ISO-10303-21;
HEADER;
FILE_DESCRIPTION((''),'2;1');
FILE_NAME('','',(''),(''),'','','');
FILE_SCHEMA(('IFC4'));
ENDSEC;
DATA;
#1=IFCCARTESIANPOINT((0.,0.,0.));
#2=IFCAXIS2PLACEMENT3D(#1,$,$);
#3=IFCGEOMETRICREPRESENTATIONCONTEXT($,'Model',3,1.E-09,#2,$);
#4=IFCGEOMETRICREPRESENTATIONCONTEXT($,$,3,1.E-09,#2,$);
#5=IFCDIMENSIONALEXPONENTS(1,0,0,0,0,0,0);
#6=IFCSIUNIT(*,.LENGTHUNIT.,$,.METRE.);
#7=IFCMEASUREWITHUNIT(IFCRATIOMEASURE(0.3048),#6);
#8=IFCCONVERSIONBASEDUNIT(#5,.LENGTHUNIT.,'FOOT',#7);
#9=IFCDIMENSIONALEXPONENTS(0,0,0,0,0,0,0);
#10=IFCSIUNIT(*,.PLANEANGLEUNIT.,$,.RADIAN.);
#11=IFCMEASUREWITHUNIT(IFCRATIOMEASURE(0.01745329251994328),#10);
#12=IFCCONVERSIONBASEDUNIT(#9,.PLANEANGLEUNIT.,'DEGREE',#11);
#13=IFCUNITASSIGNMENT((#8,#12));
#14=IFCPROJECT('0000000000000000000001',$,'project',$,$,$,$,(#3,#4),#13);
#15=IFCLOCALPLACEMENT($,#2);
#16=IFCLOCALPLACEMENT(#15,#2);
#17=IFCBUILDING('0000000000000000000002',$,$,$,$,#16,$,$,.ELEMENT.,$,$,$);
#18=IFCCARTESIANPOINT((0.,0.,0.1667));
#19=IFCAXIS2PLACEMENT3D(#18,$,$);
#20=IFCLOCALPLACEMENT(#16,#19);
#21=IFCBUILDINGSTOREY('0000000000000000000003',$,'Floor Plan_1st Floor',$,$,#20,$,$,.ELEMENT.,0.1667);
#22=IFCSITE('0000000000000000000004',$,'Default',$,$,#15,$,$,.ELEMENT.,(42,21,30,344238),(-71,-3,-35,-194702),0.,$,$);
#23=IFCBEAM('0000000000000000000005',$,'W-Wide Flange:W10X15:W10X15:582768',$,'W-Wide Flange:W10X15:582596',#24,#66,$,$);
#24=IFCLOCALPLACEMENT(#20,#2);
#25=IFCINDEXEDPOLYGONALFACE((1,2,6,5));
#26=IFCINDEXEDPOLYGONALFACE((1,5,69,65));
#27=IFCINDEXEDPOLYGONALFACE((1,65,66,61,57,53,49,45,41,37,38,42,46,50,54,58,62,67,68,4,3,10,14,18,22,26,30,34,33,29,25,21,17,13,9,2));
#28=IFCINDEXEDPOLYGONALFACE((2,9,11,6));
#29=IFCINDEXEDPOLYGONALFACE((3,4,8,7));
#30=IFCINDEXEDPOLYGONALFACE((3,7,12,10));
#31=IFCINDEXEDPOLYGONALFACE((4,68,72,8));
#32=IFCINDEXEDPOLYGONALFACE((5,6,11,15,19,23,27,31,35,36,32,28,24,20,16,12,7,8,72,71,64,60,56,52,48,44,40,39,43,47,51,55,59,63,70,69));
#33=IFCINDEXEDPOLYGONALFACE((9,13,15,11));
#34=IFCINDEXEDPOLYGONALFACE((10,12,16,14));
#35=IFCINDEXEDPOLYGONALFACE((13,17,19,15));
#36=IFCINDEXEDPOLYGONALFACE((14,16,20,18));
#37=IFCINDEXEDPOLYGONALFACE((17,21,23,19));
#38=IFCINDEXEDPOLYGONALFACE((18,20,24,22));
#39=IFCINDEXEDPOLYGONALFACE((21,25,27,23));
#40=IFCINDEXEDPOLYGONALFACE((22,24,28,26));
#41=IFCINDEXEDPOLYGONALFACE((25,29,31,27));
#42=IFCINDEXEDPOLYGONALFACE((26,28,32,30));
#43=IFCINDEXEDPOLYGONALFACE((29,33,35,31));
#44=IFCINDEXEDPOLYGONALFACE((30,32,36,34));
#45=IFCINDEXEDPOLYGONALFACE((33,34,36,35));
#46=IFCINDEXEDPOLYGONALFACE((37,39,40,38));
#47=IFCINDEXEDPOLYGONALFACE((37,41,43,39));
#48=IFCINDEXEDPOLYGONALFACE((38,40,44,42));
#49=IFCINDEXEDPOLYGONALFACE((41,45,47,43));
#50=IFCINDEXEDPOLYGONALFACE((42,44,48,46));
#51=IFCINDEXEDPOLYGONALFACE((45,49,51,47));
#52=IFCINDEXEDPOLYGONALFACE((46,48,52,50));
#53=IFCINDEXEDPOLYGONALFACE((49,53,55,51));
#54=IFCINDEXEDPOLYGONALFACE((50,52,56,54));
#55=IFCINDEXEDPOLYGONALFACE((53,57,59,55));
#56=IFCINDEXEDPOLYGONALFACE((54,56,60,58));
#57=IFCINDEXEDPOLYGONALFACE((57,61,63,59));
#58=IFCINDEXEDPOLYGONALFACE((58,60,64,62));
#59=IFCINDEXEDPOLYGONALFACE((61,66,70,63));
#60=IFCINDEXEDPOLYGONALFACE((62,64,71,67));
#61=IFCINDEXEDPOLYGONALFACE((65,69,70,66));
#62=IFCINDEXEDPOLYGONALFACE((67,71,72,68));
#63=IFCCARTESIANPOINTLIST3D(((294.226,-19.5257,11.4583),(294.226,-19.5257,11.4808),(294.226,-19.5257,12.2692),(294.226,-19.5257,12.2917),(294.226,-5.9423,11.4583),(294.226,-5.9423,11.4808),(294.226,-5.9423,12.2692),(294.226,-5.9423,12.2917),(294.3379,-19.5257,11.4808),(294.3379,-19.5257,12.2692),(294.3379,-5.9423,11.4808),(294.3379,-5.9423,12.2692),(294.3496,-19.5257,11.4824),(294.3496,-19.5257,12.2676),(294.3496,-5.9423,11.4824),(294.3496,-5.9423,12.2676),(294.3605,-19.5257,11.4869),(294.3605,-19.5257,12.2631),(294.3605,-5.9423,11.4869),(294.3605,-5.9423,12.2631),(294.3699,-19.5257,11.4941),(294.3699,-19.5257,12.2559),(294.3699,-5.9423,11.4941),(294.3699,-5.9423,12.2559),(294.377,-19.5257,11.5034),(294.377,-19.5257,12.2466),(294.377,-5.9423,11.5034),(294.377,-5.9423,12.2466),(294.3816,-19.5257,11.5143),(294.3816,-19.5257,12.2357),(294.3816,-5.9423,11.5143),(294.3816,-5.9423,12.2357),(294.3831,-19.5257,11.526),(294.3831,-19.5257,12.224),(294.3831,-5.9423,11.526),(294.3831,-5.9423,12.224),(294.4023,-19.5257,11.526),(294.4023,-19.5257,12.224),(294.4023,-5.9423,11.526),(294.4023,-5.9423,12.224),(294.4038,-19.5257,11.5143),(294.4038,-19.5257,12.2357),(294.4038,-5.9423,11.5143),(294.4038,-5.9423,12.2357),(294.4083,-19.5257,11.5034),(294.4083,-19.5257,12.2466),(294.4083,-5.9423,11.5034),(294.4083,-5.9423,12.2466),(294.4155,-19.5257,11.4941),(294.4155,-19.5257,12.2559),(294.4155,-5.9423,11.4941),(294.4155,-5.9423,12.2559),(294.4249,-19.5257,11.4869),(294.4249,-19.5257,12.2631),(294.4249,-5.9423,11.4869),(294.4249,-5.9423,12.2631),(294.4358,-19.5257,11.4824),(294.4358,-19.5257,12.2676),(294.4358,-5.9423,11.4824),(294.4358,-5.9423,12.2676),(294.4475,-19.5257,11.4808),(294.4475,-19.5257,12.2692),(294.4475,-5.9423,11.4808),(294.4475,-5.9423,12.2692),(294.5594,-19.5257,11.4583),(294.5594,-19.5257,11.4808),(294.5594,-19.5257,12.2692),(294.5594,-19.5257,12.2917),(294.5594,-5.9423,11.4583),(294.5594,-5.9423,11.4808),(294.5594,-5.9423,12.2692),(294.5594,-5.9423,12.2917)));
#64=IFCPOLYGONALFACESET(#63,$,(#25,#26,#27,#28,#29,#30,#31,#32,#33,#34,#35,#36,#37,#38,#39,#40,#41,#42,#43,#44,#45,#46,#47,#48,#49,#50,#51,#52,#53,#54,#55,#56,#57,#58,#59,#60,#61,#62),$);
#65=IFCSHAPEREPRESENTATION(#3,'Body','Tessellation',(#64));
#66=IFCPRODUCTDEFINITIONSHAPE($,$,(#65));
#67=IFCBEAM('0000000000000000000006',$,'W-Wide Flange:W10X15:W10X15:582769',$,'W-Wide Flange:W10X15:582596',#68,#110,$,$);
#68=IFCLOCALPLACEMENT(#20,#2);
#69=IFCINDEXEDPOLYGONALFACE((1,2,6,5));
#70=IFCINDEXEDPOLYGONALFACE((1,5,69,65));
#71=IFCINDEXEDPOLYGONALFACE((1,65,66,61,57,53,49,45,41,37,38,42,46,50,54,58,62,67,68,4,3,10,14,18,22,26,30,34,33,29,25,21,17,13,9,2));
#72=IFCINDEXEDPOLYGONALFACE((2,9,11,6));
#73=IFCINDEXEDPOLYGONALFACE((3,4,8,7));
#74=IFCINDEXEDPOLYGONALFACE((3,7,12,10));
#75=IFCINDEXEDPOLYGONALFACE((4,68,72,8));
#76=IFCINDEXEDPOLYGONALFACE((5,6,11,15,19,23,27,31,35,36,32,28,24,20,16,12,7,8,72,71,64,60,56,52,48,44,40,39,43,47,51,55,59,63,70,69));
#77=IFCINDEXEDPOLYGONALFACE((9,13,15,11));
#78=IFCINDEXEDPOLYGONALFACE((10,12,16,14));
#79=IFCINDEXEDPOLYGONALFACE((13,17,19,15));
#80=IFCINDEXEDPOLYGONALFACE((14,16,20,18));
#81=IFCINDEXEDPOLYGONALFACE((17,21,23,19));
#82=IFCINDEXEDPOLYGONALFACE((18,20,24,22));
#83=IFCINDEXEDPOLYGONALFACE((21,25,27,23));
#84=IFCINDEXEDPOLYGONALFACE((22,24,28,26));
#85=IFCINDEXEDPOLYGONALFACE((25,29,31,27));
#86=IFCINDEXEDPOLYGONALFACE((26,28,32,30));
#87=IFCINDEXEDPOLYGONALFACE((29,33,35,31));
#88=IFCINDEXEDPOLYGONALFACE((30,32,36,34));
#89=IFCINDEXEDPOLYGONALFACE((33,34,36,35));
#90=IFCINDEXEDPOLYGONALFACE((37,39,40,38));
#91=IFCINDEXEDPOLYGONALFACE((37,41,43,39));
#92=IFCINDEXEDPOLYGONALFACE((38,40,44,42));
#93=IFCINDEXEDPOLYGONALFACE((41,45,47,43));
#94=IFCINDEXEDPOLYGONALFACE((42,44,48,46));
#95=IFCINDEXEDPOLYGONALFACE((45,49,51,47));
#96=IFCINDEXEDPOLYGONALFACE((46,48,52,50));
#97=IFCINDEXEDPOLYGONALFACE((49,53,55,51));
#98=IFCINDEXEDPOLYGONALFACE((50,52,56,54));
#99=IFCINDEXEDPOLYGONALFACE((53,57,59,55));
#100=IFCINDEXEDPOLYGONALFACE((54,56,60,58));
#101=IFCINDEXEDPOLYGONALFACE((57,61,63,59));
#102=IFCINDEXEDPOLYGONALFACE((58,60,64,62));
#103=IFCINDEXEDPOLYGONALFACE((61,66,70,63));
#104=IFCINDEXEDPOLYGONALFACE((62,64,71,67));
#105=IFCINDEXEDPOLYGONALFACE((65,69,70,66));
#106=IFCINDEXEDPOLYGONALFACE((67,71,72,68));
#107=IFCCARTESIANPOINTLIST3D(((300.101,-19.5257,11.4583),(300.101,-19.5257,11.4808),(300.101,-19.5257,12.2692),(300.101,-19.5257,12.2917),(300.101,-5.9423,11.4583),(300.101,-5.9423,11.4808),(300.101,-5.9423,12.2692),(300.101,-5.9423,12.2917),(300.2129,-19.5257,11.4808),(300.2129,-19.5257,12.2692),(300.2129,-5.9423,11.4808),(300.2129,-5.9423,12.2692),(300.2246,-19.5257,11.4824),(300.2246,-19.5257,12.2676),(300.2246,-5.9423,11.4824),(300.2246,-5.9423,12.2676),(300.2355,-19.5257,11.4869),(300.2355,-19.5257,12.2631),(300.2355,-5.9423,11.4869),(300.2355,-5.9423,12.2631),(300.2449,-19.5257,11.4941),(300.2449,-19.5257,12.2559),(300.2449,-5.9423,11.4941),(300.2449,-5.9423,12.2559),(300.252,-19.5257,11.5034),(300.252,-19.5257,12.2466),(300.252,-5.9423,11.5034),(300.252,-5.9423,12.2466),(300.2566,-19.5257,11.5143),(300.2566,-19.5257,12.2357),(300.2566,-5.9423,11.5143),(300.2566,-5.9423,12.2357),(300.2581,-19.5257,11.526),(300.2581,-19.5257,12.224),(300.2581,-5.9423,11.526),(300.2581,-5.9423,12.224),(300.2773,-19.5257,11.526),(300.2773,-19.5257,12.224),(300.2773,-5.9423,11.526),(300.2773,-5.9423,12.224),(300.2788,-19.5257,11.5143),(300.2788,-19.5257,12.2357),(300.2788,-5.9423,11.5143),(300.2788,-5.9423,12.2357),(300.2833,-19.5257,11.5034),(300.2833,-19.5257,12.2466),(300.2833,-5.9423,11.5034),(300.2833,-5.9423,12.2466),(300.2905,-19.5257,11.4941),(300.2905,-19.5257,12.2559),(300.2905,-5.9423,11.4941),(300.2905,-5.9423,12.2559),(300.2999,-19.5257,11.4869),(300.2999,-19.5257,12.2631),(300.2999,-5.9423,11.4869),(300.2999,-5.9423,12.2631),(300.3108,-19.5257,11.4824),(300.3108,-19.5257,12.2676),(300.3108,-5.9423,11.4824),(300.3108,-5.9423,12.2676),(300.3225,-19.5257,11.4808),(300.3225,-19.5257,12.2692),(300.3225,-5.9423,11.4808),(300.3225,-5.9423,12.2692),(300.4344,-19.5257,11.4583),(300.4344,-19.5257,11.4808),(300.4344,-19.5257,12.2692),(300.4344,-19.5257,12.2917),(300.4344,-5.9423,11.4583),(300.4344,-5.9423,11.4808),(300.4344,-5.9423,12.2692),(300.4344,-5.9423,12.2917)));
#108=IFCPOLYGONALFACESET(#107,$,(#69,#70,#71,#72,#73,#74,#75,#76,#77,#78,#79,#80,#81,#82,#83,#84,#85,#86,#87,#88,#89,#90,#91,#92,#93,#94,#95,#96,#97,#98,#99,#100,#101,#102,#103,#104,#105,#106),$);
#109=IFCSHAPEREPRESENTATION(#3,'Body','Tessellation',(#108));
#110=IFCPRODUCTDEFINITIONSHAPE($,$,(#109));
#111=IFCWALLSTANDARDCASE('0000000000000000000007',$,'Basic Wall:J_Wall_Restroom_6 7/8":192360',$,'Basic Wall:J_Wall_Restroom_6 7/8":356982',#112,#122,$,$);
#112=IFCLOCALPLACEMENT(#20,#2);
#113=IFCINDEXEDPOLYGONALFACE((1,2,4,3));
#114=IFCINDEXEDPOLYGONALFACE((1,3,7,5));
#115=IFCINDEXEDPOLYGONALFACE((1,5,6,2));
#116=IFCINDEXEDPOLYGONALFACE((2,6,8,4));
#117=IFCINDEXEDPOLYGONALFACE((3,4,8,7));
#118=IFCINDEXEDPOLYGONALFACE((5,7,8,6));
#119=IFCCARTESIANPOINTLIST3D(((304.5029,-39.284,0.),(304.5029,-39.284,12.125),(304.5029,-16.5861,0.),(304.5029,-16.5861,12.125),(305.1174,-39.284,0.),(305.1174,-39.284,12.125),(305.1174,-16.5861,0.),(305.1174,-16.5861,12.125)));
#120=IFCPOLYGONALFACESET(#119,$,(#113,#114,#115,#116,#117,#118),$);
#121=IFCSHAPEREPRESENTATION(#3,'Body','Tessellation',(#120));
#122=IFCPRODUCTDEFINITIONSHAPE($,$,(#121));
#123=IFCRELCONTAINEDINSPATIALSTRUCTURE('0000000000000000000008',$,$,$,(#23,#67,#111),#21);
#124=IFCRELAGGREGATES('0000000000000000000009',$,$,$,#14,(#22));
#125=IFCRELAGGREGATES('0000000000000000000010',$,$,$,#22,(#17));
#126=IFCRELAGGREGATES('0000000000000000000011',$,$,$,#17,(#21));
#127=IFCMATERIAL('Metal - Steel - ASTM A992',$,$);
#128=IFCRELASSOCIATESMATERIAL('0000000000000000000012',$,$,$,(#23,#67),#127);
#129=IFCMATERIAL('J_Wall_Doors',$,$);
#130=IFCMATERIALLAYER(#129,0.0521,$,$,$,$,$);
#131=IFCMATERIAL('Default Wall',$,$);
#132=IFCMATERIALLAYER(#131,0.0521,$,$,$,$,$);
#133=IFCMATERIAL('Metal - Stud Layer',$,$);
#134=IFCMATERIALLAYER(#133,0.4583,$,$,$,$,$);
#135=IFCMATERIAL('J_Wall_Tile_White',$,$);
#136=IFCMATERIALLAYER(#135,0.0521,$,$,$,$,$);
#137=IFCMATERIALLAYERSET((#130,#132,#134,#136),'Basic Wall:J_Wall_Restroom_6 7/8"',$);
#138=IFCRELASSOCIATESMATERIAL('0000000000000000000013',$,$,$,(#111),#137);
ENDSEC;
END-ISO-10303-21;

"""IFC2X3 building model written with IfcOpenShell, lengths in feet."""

from ifc_helpers import new_model, entity, si_unit, converted_unit, frame, frame_2d, origin, place, context, project, spatial, polyline, circle_curve, parameter, trimmed, segment, composite_curve, rectangle, outline, extrude, clip, halfspace, material, layer, layer_set, layer_usage, element, save


model = new_model("IFC2X3")

# Units and contexts
model_context = context("Model", 3, precision=1e-09, world=origin())
context_of_model = context(None, 3, precision=1e-09, world=origin())
ifc_project = project(units=[converted_unit("LENGTHUNIT", "FOOT", entity("IfcRatioMeasure", 0.3048), si_unit("LENGTHUNIT", "METRE"), dimensions=[1, 0, 0, 0, 0, 0, 0]), converted_unit("PLANEANGLEUNIT", "DEGREE", entity("IfcRatioMeasure", 0.01745329251994328), si_unit("PLANEANGLEUNIT", "RADIAN"), dimensions=[0, 0, 0, 0, 0, 0, 0])], contexts=[model_context, context_of_model])

# Site, building, storey
site_placement = place(None, origin())
site = spatial("IfcSite", under=ifc_project, at=site_placement, Name="Default", CompositionType="ELEMENT", RefLatitude=(42, 21, 30, 344238), RefLongitude=(-71, -3, -35, -194702), RefElevation=0.0)
building_placement = place(site_placement, origin())
building = spatial("IfcBuilding", under=site, at=building_placement, CompositionType="ELEMENT")
storey_placement = place(building_placement, frame((0.0, 0.0, 0.1667)))
storey = spatial("IfcBuildingStorey", under=building, at=storey_placement, Name="Floor Plan_1st Floor", CompositionType="ELEMENT", Elevation=0.1667)

# Beams
ifc_material_1 = material(Name="Metal - Steel - ASTM A992")
beam_1_placement = place(storey_placement, frame((294.3927, -17.3748, 12.2917)))
element("IfcBeam", 1, at=beam_1_placement, inside=storey, material=ifc_material_1, Name="W-Wide Flange:W10X15:W10X15:582768", ObjectType="W-Wide Flange:W10X15:582596", context=model_context, shape_type="SweptSolid", body=[
    extrude(outline(composite_curve([segment(polyline([(-0.1667, -0.3942), (-0.1667, -0.4167)]), True, "CONTINUOUS"), segment(polyline([(-0.1667, -0.4167), (0.1667, -0.4167)]), True, "CONTINUOUS"), segment(polyline([(0.1667, -0.4167), (0.1667, -0.3942)]), True, "CONTINUOUS"), segment(polyline([(0.1667, -0.3942), (0.0548, -0.3942)]), True, "CONTINUOUS"), segment(trimmed(circle_curve(frame_2d((0.0548, -0.349), x_axis=(1.0, 0.0)), 0.0452), [parameter(180.0)], [parameter(270.0)], True, "PARAMETER"), False, "CONTINUOUS"), segment(polyline([(0.0096, -0.349), (0.0096, 0.349)]), True, "CONTINUOUS"), segment(trimmed(circle_curve(frame_2d((0.0548, 0.349), x_axis=(1.0, 0.0)), 0.0452), [parameter(90.0)], [parameter(180.0)], True, "PARAMETER"), False, "CONTINUOUS"), segment(polyline([(0.0548, 0.3942), (0.1667, 0.3942)]), True, "CONTINUOUS"), segment(polyline([(0.1667, 0.3942), (0.1667, 0.4167)]), True, "CONTINUOUS"), segment(polyline([(0.1667, 0.4167), (-0.1667, 0.4167)]), True, "CONTINUOUS"), segment(polyline([(-0.1667, 0.4167), (-0.1667, 0.3942)]), True, "CONTINUOUS"), segment(polyline([(-0.1667, 0.3942), (-0.0548, 0.3942)]), True, "CONTINUOUS"), segment(trimmed(circle_curve(frame_2d((-0.0548, 0.349), x_axis=(1.0, 0.0)), 0.0452), [parameter(360.0)], [parameter(90.0)], True, "PARAMETER"), False, "CONTINUOUS"), segment(polyline([(-0.0096, 0.349), (-0.0096, -0.349)]), True, "CONTINUOUS"), segment(trimmed(circle_curve(frame_2d((-0.0548, -0.349), x_axis=(1.0, 0.0)), 0.0452), [parameter(270.0)], [parameter(360.0)], True, "PARAMETER"), False, "CONTINUOUS"), segment(polyline([(-0.0548, -0.3942), (-0.1667, -0.3942)]), True, "CONTINUOUS")], self_intersect=False)), frame((0.0, -2.1509, -0.4167), z_axis=(0.0, -1.0, 0.0), x_axis=(1.0, 0.0, 0.0)), (0.0, 0.0, -1.0), 13.5833),
])
beam_2_placement = place(storey_placement, frame((300.2677, -17.3748, 12.2917)))
element("IfcBeam", 2, at=beam_2_placement, inside=storey, material=ifc_material_1, Name="W-Wide Flange:W10X15:W10X15:582769", ObjectType="W-Wide Flange:W10X15:582596", context=model_context, shape_type="SweptSolid", body=[
    extrude(outline(composite_curve([segment(polyline([(-0.1667, -0.3942), (-0.1667, -0.4167)]), True, "CONTINUOUS"), segment(polyline([(-0.1667, -0.4167), (0.1667, -0.4167)]), True, "CONTINUOUS"), segment(polyline([(0.1667, -0.4167), (0.1667, -0.3942)]), True, "CONTINUOUS"), segment(polyline([(0.1667, -0.3942), (0.0548, -0.3942)]), True, "CONTINUOUS"), segment(trimmed(circle_curve(frame_2d((0.0548, -0.349), x_axis=(1.0, 0.0)), 0.0452), [parameter(180.0)], [parameter(270.0)], True, "PARAMETER"), False, "CONTINUOUS"), segment(polyline([(0.0096, -0.349), (0.0096, 0.349)]), True, "CONTINUOUS"), segment(trimmed(circle_curve(frame_2d((0.0548, 0.349), x_axis=(1.0, 0.0)), 0.0452), [parameter(90.0)], [parameter(180.0)], True, "PARAMETER"), False, "CONTINUOUS"), segment(polyline([(0.0548, 0.3942), (0.1667, 0.3942)]), True, "CONTINUOUS"), segment(polyline([(0.1667, 0.3942), (0.1667, 0.4167)]), True, "CONTINUOUS"), segment(polyline([(0.1667, 0.4167), (-0.1667, 0.4167)]), True, "CONTINUOUS"), segment(polyline([(-0.1667, 0.4167), (-0.1667, 0.3942)]), True, "CONTINUOUS"), segment(polyline([(-0.1667, 0.3942), (-0.0548, 0.3942)]), True, "CONTINUOUS"), segment(trimmed(circle_curve(frame_2d((-0.0548, 0.349), x_axis=(1.0, 0.0)), 0.0452), [parameter(360.0)], [parameter(90.0)], True, "PARAMETER"), False, "CONTINUOUS"), segment(polyline([(-0.0096, 0.349), (-0.0096, -0.349)]), True, "CONTINUOUS"), segment(trimmed(circle_curve(frame_2d((-0.0548, -0.349), x_axis=(1.0, 0.0)), 0.0452), [parameter(270.0)], [parameter(360.0)], True, "PARAMETER"), False, "CONTINUOUS"), segment(polyline([(-0.0548, -0.3942), (-0.1667, -0.3942)]), True, "CONTINUOUS")], self_intersect=False)), frame((0.0, -2.1509, -0.4167), z_axis=(0.0, -1.0, 0.0), x_axis=(1.0, 0.0, 0.0)), (0.0, 0.0, -1.0), 13.5833),
])

# Wall
ifc_material_2 = material(Name="J_Wall_Doors")
ifc_layer_1 = layer(ifc_material_2, 0.0521)
ifc_material_3 = material(Name="Default Wall")
ifc_layer_2 = layer(ifc_material_3, 0.0521)
ifc_material_4 = material(Name="Metal - Stud Layer")
ifc_layer_3 = layer(ifc_material_4, 0.4583)
ifc_material_5 = material(Name="J_Wall_Tile_White")
ifc_layer_4 = layer(ifc_material_5, 0.0521)
ifc_layer_set_1 = layer_set([ifc_layer_1, ifc_layer_2, ifc_layer_3, ifc_layer_4], Name="Basic Wall:J_Wall_Restroom_6 7/8\"")
ifc_layer_usage_1 = layer_usage(ifc_layer_set_1, "AXIS2", "POSITIVE", -0.3073)
wall_1_placement = place(storey_placement, frame((304.8101, -16.5861, 0.0), z_axis=(0.0, 0.0, 1.0), x_axis=(0.0, -1.0, 0.0)))
element("IfcWallStandardCase", 3, at=wall_1_placement, inside=storey, material=ifc_layer_usage_1, Name="Basic Wall:J_Wall_Restroom_6 7/8\":192360", ObjectType="Basic Wall:J_Wall_Restroom_6 7/8\":356982", context=model_context, shape_type="Clipping", body=[
    clip(extrude(rectangle(XDim=22.6979, YDim=0.6146, at=frame_2d((11.349, 0.0), x_axis=(-1.0, 0.0))), origin(), (0.0, 0.0, 1.0), 12.125), halfspace(origin(), True)),
])

save(model, "model.ifc")
